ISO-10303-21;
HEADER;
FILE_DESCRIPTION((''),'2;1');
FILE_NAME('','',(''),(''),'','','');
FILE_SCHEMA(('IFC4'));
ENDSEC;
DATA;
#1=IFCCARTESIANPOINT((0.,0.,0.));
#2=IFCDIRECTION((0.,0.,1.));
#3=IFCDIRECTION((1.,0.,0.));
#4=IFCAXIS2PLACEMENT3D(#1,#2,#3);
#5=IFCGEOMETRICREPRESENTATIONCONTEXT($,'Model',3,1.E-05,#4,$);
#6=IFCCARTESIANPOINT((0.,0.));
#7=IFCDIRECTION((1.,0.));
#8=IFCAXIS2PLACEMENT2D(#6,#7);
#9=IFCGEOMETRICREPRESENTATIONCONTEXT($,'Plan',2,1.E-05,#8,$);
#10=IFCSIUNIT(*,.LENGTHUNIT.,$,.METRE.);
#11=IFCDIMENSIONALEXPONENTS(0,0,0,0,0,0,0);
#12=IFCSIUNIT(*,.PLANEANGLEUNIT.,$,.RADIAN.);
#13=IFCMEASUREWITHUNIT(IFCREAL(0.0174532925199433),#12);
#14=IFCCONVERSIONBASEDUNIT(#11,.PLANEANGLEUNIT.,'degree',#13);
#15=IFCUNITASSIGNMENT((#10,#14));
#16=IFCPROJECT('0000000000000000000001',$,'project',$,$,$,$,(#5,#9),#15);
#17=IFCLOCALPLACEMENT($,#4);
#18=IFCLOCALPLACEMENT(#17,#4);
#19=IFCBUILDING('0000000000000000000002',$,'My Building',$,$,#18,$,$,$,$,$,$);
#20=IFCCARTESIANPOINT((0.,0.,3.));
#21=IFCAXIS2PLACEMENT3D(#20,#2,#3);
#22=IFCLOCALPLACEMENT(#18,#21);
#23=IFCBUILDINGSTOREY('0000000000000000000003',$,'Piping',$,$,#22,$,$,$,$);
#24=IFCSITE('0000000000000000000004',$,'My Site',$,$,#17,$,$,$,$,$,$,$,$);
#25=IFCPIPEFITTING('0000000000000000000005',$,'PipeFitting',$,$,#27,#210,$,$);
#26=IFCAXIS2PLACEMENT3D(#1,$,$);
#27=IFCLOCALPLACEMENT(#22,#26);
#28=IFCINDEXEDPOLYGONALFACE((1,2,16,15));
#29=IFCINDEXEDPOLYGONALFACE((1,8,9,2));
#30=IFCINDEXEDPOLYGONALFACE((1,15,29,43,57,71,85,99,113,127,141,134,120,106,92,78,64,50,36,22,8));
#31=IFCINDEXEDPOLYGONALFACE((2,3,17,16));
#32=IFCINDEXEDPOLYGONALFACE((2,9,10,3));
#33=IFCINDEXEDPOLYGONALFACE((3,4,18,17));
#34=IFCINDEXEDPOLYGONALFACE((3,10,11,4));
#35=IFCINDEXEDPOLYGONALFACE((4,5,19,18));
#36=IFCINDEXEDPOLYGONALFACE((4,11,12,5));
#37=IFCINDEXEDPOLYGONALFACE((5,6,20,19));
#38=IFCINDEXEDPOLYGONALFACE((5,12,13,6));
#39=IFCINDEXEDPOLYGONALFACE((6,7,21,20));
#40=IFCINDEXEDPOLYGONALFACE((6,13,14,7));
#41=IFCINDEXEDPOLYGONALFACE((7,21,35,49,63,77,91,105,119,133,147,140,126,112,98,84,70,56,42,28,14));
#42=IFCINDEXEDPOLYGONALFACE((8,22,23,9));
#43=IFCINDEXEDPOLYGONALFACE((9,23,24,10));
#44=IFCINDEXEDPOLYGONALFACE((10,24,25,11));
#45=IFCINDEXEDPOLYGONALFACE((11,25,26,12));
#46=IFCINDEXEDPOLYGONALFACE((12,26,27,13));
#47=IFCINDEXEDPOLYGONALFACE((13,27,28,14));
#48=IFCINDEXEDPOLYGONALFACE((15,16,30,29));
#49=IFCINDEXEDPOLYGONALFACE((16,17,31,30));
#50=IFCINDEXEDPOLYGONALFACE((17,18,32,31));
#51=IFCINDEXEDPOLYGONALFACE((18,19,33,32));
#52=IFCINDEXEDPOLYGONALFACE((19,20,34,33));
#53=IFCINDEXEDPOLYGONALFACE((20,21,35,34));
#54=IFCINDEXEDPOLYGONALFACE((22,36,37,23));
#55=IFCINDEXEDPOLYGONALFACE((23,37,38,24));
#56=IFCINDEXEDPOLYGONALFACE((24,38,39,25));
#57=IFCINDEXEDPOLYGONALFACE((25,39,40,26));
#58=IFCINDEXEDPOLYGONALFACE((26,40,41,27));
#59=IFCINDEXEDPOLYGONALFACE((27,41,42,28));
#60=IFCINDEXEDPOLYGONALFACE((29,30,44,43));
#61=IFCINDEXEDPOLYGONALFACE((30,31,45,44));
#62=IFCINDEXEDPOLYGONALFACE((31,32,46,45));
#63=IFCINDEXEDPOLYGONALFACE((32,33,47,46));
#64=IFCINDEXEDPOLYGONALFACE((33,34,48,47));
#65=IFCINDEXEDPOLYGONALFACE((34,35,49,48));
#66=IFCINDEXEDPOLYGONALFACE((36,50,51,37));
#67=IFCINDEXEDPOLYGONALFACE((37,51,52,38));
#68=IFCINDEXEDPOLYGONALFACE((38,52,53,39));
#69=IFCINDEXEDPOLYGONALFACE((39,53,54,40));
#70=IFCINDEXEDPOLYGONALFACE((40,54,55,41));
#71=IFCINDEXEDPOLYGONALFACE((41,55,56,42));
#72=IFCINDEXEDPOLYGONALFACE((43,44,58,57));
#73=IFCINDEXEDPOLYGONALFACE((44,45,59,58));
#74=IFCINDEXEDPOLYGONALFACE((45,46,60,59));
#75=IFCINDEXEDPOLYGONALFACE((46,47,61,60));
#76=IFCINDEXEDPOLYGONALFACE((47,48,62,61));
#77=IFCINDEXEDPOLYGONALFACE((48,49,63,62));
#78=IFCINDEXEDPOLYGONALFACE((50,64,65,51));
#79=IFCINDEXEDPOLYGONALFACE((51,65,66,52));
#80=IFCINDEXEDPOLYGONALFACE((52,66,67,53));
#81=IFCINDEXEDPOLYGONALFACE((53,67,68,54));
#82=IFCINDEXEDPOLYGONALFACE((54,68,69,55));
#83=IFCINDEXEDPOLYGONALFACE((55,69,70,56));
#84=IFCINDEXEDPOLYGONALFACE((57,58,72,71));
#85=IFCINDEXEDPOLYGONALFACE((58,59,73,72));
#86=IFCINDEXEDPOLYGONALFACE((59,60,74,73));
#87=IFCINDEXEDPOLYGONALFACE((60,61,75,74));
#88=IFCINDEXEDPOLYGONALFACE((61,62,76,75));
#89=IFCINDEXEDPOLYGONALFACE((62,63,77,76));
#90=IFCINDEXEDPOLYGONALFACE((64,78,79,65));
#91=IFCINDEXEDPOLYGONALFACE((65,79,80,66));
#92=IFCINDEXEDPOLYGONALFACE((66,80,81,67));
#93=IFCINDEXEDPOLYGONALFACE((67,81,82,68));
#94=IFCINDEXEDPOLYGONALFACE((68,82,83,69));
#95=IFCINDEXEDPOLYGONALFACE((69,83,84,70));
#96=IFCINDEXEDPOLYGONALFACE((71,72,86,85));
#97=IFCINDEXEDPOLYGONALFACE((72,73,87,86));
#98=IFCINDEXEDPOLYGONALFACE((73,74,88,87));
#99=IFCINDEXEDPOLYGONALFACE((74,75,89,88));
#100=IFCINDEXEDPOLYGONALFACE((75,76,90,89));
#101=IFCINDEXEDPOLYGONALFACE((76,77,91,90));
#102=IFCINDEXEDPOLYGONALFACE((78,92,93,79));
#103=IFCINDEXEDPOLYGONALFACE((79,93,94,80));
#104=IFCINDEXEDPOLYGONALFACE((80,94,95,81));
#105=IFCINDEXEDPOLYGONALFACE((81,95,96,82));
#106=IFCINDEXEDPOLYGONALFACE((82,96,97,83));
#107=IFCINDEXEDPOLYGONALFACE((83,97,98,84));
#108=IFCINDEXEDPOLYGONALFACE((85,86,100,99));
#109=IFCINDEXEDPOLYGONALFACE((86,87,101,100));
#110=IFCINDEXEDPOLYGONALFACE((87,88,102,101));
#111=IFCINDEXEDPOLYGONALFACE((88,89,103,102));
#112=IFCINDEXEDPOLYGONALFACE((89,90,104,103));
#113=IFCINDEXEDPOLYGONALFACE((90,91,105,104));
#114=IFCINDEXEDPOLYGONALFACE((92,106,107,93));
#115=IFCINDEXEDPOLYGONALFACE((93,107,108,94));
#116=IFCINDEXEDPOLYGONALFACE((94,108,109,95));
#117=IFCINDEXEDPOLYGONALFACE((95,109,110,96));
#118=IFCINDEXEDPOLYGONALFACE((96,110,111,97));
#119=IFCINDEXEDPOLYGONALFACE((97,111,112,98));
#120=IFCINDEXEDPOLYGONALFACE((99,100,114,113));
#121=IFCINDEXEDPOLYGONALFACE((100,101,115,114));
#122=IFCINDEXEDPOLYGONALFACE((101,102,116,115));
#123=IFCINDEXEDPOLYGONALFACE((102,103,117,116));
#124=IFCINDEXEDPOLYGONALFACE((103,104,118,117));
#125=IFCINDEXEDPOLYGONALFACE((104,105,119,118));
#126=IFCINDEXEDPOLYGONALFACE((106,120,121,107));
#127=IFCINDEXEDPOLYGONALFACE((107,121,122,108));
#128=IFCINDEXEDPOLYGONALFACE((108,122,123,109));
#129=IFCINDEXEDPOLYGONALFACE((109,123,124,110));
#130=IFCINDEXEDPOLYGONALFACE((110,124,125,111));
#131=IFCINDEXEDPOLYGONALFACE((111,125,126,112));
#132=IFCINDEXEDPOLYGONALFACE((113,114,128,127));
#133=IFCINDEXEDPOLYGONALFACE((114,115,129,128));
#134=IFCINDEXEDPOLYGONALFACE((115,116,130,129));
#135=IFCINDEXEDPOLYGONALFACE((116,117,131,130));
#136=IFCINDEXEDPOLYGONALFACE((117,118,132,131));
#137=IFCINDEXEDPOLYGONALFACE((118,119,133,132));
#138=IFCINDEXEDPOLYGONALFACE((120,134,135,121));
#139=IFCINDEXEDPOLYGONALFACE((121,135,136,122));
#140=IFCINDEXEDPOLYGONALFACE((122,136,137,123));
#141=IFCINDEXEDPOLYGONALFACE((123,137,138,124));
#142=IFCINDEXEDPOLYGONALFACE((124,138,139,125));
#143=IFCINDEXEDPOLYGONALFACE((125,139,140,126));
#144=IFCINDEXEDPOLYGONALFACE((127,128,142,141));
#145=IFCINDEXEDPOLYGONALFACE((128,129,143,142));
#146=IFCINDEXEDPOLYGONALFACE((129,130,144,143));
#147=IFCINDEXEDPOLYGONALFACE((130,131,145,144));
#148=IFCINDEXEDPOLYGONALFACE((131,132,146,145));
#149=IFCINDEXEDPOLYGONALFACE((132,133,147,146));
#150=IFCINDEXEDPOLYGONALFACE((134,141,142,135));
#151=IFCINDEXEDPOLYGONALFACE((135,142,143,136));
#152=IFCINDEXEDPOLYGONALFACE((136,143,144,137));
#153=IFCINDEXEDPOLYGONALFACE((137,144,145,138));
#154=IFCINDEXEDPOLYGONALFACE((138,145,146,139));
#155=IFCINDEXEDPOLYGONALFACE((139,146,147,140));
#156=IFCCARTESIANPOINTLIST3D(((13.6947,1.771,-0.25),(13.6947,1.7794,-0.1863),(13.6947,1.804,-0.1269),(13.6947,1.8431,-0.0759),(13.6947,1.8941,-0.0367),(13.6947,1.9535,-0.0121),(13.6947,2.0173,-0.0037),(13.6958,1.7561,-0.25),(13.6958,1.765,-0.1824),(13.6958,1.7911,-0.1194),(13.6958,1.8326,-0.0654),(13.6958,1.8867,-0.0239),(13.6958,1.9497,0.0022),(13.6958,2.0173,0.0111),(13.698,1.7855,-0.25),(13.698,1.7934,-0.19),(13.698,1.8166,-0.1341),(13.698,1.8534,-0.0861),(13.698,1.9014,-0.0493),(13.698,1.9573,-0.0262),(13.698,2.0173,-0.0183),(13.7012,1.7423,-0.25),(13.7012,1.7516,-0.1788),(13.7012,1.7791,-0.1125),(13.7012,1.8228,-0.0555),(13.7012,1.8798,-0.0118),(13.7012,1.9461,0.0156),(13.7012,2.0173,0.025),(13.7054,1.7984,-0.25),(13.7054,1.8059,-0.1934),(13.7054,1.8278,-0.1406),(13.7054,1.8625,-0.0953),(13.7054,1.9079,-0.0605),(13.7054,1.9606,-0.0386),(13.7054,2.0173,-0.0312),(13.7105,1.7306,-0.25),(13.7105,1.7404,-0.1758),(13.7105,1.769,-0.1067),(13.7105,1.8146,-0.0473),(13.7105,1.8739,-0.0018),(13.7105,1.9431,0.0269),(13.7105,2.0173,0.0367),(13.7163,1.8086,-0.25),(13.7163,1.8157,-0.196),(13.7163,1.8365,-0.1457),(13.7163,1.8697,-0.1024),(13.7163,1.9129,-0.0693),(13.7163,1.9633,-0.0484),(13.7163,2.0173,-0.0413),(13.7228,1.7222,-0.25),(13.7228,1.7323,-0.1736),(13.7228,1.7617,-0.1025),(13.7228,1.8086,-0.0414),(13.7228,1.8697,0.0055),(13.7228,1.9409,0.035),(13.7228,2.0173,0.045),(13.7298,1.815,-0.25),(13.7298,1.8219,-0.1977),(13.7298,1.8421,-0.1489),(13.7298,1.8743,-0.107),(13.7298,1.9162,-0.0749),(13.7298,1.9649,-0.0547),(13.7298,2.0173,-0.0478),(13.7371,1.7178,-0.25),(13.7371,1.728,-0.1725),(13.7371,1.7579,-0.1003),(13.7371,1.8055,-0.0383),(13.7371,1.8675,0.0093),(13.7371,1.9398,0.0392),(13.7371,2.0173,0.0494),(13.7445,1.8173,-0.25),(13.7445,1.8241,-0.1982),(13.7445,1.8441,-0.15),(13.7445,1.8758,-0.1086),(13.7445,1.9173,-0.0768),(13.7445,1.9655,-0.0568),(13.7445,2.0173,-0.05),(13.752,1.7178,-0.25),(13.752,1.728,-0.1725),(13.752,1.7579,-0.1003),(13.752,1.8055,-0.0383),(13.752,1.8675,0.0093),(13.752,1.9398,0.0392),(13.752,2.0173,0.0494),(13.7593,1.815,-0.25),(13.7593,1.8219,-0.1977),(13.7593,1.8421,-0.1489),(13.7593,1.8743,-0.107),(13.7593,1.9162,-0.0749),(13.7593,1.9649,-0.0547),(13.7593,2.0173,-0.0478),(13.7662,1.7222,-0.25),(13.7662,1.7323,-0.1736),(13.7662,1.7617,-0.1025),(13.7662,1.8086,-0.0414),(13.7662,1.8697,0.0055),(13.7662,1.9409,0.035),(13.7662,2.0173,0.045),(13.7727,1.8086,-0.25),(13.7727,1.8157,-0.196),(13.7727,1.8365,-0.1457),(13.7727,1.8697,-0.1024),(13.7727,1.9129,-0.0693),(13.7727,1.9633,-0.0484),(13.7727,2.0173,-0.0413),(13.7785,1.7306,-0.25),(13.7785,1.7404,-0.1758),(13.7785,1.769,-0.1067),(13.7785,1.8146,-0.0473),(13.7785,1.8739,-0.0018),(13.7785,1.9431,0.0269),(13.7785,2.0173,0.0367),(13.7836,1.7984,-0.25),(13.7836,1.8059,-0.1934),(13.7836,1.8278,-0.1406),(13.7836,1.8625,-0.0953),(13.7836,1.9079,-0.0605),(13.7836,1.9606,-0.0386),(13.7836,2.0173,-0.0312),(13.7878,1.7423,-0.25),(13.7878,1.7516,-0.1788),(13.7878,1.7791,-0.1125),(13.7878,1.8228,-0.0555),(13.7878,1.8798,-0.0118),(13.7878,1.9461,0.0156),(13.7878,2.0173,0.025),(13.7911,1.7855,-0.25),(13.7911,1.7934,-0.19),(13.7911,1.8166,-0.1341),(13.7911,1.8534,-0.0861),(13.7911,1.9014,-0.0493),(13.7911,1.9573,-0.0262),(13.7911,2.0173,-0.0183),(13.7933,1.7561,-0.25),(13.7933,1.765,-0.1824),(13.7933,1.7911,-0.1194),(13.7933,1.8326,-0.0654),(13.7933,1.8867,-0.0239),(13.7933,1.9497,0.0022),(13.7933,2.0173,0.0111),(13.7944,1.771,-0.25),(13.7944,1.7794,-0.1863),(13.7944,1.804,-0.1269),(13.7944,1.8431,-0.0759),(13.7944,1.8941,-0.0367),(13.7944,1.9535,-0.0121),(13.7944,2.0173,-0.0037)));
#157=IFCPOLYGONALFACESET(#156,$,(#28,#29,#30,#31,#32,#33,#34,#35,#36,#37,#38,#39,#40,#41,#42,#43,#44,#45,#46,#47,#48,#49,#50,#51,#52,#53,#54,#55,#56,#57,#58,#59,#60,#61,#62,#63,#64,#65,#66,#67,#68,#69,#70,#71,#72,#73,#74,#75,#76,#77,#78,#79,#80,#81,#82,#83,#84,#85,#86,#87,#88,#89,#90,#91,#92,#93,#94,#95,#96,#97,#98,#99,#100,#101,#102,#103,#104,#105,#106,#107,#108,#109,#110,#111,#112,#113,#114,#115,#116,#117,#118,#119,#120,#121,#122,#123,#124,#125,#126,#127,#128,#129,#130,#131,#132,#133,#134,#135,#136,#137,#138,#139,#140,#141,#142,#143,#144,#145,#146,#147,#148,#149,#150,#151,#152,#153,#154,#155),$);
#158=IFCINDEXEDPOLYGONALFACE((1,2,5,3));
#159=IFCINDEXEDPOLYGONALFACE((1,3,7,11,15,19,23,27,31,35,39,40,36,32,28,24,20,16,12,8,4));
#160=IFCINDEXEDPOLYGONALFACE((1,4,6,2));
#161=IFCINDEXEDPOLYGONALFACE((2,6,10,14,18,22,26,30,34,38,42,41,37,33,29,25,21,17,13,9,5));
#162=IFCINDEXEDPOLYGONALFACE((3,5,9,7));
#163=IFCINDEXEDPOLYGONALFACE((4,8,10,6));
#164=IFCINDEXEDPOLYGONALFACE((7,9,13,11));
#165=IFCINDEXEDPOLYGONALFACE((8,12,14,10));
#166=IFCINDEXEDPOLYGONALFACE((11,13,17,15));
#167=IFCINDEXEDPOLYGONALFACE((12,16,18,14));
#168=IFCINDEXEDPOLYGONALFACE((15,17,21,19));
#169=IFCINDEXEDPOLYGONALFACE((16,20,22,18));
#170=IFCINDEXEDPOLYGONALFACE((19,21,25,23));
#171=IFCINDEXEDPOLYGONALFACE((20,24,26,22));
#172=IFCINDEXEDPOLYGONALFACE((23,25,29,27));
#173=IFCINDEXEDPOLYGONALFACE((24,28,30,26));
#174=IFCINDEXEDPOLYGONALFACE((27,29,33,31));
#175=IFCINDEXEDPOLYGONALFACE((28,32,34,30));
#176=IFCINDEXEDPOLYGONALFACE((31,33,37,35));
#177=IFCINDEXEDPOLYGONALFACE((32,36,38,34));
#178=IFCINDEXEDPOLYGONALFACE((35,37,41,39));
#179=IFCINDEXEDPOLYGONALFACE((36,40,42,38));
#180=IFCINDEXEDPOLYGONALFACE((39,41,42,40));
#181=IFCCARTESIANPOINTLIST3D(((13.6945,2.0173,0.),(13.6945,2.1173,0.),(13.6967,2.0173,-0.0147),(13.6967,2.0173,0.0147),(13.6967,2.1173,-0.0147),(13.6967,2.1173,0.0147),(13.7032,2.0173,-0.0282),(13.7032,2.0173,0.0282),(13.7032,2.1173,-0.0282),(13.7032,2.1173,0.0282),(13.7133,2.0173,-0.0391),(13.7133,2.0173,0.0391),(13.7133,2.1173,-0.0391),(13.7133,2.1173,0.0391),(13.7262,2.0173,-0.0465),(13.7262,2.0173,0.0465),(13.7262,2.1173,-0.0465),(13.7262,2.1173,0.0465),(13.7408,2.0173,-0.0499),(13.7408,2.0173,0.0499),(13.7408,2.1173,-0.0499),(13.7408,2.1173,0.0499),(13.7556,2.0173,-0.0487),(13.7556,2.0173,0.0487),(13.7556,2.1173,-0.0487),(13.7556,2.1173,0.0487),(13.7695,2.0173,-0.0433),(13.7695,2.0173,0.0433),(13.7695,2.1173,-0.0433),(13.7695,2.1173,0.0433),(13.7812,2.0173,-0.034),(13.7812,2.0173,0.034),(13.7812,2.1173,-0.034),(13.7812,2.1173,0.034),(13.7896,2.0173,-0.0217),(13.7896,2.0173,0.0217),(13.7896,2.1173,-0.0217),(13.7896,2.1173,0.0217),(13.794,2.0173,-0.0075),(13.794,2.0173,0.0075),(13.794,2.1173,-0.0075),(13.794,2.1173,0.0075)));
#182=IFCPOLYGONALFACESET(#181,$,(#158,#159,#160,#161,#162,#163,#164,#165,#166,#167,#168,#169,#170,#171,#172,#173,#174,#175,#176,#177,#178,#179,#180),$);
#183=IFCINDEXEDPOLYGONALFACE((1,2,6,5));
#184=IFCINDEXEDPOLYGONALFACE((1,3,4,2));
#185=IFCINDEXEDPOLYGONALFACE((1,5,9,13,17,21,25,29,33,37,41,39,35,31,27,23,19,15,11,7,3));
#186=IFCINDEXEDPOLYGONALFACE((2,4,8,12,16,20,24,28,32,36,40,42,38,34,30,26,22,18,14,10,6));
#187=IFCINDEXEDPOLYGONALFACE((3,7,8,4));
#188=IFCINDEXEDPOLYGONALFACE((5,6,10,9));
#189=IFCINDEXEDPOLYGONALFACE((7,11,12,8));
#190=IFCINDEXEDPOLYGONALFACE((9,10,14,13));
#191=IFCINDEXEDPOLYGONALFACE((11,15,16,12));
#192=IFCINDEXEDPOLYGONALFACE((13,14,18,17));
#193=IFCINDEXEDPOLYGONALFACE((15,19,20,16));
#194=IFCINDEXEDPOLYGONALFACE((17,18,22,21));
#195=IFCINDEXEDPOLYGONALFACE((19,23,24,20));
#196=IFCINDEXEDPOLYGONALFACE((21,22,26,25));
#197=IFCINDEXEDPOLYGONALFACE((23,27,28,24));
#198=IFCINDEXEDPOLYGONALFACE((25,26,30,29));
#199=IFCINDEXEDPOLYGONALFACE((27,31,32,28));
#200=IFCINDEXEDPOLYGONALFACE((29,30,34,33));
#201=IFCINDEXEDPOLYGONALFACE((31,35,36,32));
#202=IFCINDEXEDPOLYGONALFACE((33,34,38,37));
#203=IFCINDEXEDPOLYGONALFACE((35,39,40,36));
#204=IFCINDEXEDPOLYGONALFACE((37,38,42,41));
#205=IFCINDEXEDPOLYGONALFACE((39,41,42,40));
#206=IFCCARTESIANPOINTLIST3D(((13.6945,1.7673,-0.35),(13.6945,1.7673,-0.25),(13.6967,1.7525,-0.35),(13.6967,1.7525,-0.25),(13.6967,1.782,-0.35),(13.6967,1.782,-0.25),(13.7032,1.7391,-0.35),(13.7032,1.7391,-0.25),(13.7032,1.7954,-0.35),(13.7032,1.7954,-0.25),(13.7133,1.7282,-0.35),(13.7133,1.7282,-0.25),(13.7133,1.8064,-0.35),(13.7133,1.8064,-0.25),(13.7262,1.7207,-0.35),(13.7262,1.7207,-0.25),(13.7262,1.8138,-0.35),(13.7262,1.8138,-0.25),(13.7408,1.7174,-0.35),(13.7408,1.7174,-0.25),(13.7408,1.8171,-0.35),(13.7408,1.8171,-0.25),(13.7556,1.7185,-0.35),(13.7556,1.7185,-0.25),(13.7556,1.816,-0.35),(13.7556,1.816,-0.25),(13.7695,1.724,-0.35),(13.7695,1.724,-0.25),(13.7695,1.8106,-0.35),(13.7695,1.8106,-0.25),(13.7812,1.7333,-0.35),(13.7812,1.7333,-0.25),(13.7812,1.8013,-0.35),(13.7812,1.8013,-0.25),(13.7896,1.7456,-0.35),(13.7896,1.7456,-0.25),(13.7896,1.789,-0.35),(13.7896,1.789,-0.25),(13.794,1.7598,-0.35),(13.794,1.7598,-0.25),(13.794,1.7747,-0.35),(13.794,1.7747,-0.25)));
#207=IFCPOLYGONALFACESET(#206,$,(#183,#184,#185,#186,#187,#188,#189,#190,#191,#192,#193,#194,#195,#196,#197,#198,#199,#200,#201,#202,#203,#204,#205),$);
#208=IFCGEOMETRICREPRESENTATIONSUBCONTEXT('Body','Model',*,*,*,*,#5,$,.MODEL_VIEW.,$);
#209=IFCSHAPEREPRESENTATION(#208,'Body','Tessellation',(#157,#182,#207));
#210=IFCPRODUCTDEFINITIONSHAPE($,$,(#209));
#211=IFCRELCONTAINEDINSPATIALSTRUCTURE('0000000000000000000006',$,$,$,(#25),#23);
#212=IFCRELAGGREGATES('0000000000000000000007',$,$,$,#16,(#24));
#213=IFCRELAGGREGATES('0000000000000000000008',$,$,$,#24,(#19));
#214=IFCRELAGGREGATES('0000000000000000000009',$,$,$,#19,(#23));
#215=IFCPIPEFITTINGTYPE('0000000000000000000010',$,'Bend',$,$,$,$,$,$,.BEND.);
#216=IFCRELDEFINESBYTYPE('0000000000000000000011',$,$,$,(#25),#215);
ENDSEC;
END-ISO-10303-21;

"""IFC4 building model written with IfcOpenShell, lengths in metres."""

from ifc_helpers import new_model, entity, si_unit, converted_unit, frame, origin_with_axes, origin_2d_with_axis, place, context, subcontext, project, spatial, circle, extrude, source, transform, mapped, type_object, type_shapes, element, save


model = new_model("IFC4")

# Units and contexts
model_context = context("Model", 3, precision=1e-05, world=origin_with_axes())
plan_context = context("Plan", 2, precision=1e-05, world=origin_2d_with_axis())
body_context = subcontext(model_context, "Body", "Model", "MODEL_VIEW")
ifc_project = project(units=[si_unit("LENGTHUNIT", "METRE"), converted_unit("PLANEANGLEUNIT", "degree", entity("IfcReal", 0.0174532925199433), si_unit("PLANEANGLEUNIT", "RADIAN"), dimensions=[0, 0, 0, 0, 0, 0, 0])], contexts=[model_context, plan_context])

# Site, building, storey
site_placement = place(None, origin_with_axes())
site = spatial("IfcSite", under=ifc_project, at=site_placement, Name="My Site")
building_placement = place(site_placement, origin_with_axes())
building = spatial("IfcBuilding", under=site, at=building_placement, Name="My Building")
storey_placement = place(building_placement, frame((0.0, 0.0, 3.0), z_axis=(0.0, 0.0, 1.0), x_axis=(1.0, 0.0, 0.0)))
storey = spatial("IfcBuildingStorey", under=building, at=storey_placement, Name="Piping")

# Pipe fitting
pipe_fitting_type = type_object("IfcPipeFittingType", Name="Bend", PredefinedType="BEND")
shared_shape = source(origin_with_axes(), body_context, "Body", "SolidModel", [
    entity("IfcSweptDiskSolid", entity("IfcIndexedPolyCurve", entity("IfcCartesianPointList3D", [[0.0, 0.0, -0.1], [0.0, -0.0732, -0.2768], [0.0, -0.25, -0.35]]), [entity("IfcArcIndex", [1, 2, 3])]), 0.05),
    extrude(circle(Radius=0.05), origin_with_axes(), (0.0, 0.0, -1.0), 0.1),
    extrude(circle(Radius=0.05), frame((0.0, -0.25, -0.35), z_axis=(0.0, -1.0, 0.0), x_axis=(1.0, 0.0, 0.0)), (0.0, 0.0, 1.0), 0.1),
])
type_shapes(pipe_fitting_type, [shared_shape])
for number, where, z_axis, x_axis, name in (
    (1, (13.7445, 2.1173, 0.0), (0.0, 1.0, 0.0), (-1.0, 0.0, 0.0), "PipeFitting"),
):
    element("IfcPipeFitting", number, at=place(storey_placement, frame(where, z_axis=z_axis, x_axis=x_axis)), inside=storey, type_object=pipe_fitting_type, Name=name, context=body_context, shape_type="MappedRepresentation", body=[
        mapped(shared_shape, transform((0.0, 0.0, 0.0), x_axis=(1.0, 0.0, 0.0), y_axis=(0.0, 1.0, 0.0), z_axis=(0.0, 0.0, 1.0), scale=1.0)),
    ])

save(model, "model.ifc")
